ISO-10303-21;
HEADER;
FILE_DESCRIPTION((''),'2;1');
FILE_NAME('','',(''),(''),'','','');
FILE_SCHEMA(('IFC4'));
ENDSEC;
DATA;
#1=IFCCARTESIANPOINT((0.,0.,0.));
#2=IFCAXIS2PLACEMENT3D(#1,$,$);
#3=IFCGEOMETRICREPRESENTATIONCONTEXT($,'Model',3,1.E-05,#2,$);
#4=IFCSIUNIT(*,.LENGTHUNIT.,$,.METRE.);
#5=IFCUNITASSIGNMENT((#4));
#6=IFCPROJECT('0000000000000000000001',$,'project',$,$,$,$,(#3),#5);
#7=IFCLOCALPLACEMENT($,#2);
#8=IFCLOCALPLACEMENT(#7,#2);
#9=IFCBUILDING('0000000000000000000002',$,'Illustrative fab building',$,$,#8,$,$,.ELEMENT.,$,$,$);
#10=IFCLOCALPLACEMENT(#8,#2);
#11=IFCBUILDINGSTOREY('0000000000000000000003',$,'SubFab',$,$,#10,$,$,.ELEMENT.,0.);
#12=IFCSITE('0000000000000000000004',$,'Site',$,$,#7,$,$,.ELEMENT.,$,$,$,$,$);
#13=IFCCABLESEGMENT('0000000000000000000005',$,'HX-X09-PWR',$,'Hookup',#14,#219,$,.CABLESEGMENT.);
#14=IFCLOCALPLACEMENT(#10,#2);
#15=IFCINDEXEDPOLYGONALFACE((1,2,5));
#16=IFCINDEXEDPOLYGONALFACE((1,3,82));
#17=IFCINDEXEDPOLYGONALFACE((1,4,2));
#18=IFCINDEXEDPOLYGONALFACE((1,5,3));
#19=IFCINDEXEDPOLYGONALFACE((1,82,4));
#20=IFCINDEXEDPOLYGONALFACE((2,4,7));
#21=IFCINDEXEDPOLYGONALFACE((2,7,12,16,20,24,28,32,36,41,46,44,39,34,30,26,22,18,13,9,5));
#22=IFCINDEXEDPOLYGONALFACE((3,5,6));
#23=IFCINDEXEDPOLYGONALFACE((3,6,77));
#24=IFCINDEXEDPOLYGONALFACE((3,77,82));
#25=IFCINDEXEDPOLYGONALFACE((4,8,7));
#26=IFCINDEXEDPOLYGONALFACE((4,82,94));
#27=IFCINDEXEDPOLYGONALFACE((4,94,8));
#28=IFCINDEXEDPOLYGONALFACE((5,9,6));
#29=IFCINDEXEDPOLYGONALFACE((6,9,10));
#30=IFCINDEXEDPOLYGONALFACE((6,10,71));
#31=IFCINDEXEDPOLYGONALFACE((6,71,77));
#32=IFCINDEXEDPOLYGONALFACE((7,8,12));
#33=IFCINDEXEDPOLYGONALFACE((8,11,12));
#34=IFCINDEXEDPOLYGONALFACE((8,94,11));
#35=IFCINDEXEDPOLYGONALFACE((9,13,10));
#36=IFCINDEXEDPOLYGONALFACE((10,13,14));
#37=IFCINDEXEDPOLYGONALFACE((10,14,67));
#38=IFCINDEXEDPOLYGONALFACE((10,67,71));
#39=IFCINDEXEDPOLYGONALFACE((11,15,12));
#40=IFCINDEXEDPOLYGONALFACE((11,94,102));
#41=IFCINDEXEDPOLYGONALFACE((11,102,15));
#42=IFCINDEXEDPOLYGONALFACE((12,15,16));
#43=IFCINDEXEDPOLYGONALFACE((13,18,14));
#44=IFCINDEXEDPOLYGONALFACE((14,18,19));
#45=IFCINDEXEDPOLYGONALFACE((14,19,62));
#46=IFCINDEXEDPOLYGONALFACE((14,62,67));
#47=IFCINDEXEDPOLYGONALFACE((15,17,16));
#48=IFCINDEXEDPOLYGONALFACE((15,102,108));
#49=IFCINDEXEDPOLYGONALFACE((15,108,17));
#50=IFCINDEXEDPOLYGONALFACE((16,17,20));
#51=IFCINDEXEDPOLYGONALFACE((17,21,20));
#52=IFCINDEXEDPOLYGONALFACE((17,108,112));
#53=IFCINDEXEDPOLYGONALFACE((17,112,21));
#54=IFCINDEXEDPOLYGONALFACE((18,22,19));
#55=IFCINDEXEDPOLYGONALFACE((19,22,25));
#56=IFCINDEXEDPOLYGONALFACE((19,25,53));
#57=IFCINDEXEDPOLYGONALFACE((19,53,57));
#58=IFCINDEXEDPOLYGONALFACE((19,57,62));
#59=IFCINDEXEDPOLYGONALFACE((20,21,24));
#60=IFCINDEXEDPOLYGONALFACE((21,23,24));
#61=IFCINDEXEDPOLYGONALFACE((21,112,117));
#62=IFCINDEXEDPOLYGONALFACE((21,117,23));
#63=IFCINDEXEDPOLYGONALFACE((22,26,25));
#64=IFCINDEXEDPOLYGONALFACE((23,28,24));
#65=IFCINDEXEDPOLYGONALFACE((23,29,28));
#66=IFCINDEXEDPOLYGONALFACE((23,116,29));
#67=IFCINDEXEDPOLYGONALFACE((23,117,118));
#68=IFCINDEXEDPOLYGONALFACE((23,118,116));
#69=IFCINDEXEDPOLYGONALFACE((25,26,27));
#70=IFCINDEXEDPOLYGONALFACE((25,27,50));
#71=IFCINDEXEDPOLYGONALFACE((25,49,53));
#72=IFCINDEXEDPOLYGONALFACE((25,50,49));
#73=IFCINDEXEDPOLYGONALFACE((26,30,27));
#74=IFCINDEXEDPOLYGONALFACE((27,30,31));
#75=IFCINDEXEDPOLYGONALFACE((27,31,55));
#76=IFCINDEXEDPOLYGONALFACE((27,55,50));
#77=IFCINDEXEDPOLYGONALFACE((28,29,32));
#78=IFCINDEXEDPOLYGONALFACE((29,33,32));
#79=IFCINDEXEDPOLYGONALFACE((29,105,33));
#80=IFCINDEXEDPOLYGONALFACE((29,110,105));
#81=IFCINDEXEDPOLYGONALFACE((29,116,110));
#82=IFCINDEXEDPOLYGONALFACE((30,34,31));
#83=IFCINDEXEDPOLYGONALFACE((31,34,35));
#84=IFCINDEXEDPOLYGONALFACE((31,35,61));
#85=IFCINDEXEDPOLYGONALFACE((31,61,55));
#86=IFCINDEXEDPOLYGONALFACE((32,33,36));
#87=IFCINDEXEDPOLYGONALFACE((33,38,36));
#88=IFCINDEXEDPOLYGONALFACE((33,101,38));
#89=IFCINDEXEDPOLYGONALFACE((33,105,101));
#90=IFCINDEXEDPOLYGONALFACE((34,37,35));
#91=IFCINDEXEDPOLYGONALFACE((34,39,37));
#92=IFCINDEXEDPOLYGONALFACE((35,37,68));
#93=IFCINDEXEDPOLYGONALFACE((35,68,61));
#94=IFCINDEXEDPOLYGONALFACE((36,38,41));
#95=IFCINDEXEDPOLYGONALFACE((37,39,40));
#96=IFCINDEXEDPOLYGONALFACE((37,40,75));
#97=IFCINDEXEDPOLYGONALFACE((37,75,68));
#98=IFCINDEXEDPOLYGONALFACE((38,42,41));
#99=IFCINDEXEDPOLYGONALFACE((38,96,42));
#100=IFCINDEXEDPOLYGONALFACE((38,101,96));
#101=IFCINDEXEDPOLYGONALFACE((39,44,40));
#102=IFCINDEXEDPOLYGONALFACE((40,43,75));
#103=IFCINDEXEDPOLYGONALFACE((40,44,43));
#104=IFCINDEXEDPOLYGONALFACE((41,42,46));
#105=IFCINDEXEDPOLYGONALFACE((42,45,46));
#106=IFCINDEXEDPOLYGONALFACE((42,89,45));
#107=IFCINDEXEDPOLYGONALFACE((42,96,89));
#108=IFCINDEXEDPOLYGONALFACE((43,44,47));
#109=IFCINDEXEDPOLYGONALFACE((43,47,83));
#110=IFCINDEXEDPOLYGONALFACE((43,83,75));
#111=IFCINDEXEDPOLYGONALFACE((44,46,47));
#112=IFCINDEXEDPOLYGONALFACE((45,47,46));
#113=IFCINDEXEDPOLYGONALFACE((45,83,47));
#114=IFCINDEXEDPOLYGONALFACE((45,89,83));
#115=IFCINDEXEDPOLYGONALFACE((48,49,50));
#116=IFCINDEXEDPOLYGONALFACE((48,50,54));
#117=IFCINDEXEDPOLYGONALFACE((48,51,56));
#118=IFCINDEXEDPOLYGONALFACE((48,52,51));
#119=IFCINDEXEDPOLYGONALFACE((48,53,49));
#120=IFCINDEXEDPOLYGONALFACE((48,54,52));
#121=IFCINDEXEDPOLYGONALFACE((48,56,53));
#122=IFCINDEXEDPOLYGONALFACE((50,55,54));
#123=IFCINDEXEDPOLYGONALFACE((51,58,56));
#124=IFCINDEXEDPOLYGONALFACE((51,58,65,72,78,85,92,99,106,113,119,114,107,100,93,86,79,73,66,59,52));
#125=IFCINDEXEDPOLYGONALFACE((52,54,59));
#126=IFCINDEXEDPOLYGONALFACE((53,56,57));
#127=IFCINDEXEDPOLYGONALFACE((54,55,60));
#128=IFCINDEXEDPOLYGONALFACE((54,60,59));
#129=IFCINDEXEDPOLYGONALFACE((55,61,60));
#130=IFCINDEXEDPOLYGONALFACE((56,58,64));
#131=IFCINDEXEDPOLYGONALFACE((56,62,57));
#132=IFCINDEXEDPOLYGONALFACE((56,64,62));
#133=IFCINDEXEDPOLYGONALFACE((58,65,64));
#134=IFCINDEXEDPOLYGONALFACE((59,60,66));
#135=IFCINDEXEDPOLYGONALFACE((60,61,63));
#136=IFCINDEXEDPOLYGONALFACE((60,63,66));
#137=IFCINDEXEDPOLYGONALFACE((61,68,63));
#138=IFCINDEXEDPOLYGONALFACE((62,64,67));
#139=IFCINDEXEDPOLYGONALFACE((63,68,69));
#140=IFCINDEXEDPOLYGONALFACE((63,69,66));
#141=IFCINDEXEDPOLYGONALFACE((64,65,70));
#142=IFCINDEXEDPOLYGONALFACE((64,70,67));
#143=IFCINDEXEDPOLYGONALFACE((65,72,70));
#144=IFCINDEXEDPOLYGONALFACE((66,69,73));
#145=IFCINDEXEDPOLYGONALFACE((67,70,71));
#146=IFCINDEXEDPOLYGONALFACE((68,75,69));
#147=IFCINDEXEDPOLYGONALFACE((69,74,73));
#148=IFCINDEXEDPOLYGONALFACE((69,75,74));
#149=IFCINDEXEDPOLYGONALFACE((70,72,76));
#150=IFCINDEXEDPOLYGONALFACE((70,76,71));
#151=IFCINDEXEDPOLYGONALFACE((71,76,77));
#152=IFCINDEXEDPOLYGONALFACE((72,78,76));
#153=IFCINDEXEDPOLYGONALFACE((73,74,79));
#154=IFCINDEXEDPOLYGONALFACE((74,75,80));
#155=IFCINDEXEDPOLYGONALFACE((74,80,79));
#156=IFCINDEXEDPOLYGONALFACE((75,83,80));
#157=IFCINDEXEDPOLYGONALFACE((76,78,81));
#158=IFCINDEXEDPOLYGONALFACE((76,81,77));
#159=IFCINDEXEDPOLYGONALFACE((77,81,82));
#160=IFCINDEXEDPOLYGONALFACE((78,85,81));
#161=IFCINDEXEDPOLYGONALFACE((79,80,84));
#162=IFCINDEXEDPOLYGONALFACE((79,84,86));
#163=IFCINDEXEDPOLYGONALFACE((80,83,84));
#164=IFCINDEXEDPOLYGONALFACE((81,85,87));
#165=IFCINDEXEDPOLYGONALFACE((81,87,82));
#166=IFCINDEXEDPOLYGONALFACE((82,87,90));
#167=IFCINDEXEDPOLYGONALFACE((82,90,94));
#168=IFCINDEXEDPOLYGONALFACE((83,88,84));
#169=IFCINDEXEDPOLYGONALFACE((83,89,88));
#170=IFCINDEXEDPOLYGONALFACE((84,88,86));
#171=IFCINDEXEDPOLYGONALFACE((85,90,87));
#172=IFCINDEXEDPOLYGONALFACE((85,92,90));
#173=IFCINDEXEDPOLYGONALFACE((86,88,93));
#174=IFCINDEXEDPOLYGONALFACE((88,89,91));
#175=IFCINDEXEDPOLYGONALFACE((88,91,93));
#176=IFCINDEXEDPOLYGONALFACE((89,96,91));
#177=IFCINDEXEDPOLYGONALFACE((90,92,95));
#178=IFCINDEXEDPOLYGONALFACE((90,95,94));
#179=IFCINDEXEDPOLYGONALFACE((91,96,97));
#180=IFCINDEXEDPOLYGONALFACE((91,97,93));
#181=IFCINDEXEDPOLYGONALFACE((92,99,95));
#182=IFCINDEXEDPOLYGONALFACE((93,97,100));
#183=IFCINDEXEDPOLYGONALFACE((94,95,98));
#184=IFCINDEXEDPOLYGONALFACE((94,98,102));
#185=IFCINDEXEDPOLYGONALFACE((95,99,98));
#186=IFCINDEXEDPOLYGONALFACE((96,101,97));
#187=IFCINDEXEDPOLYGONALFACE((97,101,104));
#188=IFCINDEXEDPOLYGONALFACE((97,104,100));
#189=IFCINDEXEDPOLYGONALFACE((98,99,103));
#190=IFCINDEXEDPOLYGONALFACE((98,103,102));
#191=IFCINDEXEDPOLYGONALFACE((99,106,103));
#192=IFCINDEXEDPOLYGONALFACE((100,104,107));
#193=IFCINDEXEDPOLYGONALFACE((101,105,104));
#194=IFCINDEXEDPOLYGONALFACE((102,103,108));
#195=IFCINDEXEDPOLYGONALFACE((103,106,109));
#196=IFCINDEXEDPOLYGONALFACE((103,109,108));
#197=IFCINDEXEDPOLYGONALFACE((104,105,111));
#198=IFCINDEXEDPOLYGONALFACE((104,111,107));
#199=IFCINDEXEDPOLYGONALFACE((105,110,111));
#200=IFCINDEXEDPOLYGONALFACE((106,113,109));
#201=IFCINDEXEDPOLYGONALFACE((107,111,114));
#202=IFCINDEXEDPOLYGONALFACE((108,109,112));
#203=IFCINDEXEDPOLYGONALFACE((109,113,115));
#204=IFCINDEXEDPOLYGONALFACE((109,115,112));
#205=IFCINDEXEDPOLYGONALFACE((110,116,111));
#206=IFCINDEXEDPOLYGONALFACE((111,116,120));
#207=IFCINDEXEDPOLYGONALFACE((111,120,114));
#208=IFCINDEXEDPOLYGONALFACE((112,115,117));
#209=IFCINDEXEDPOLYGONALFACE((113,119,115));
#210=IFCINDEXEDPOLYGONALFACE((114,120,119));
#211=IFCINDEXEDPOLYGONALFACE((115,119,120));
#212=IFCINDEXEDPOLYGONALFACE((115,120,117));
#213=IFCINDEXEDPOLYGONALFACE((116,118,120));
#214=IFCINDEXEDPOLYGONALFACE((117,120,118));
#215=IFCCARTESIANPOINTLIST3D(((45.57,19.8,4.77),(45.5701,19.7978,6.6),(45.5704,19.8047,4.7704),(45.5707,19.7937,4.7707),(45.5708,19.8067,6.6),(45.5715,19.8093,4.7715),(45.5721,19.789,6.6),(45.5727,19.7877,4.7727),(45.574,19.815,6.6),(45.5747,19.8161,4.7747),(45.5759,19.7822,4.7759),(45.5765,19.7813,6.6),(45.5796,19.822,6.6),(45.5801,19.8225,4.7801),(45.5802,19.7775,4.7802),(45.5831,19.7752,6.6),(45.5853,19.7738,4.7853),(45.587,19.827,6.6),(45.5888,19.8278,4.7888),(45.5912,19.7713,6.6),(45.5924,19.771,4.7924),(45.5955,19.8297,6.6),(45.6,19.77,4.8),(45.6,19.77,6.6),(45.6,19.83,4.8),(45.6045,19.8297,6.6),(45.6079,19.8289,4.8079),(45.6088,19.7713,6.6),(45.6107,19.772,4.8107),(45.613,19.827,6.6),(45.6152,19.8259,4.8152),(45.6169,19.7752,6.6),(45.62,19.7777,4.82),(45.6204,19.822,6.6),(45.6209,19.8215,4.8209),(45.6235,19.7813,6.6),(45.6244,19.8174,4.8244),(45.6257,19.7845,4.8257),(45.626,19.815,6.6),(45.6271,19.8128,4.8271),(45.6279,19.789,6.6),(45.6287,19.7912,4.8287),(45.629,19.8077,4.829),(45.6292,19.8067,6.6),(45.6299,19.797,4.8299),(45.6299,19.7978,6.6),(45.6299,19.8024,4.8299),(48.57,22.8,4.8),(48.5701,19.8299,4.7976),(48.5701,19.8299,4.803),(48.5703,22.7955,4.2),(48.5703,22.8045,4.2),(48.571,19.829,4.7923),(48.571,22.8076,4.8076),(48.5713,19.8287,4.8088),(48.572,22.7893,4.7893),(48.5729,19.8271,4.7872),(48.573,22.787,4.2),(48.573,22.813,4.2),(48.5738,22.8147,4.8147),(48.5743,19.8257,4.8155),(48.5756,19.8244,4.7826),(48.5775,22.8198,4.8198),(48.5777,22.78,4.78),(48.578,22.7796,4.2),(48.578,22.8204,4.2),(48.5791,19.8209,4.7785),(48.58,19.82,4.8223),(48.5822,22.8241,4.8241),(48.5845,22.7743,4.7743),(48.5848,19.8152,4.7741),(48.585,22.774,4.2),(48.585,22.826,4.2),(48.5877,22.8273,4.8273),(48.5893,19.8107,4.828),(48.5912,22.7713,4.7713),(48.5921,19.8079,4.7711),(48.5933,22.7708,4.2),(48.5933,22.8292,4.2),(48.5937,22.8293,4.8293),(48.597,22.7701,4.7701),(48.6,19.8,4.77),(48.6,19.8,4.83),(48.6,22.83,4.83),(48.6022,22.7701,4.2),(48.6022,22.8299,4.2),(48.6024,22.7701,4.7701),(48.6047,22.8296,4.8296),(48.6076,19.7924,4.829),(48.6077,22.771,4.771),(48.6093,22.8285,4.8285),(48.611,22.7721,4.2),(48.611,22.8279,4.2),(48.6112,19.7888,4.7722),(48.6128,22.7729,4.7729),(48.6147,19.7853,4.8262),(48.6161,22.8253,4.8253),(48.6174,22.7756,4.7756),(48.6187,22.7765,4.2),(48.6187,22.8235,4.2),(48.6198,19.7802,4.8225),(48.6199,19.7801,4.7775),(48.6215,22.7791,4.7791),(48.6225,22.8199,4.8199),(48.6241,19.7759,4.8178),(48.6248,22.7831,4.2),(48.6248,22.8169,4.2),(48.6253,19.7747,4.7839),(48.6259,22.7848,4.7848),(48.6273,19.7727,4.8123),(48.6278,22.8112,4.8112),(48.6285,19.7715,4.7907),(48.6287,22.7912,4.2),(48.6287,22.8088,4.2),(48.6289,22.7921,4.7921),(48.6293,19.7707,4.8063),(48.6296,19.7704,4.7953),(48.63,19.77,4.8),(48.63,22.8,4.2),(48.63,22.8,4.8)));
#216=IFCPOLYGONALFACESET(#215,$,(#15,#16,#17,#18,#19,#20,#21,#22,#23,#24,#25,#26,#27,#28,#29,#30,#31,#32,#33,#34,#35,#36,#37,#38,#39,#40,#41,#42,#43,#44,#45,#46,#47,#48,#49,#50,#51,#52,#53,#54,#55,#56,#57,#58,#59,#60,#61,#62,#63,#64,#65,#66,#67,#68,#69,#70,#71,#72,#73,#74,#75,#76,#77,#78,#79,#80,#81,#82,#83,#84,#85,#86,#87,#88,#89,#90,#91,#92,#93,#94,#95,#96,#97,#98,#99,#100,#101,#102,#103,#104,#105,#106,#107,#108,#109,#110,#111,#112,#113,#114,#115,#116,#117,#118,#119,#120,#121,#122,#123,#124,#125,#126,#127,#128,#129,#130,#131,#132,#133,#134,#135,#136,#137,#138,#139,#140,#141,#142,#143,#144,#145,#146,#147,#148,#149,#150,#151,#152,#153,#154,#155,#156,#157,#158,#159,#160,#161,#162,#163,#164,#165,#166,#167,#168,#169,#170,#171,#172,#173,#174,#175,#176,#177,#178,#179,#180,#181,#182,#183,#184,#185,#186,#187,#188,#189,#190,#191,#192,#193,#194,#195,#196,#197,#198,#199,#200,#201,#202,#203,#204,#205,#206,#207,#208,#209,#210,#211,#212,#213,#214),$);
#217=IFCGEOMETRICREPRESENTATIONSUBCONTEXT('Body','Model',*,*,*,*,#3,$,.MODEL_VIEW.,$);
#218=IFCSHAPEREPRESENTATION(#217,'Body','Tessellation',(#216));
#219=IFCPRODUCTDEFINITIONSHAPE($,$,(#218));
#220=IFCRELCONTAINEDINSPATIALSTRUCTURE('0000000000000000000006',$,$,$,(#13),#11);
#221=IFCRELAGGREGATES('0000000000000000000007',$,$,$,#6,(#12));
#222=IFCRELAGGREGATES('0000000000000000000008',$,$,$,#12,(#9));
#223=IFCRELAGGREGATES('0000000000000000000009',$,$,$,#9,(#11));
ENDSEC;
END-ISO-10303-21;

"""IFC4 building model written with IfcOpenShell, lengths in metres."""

from ifc_helpers import new_model, entity, si_unit, origin, place, context, subcontext, project, spatial, element, save


model = new_model("IFC4")

# Units and contexts
model_context = context("Model", 3, precision=1e-05, world=origin())
body_context = subcontext(model_context, "Body", "Model", "MODEL_VIEW")
ifc_project = project(units=[si_unit("LENGTHUNIT", "METRE")], contexts=[model_context])

# Site, building, storey
site_placement = place(None, origin())
site = spatial("IfcSite", under=ifc_project, at=site_placement, Name="Site", CompositionType="ELEMENT")
building_placement = place(site_placement, origin())
building = spatial("IfcBuilding", under=site, at=building_placement, Name="Illustrative fab building", CompositionType="ELEMENT")
storey_placement = place(building_placement, origin())
storey = spatial("IfcBuildingStorey", under=building, at=storey_placement, Name="SubFab", CompositionType="ELEMENT", Elevation=0.0)

# Cable segment
cable_segment_1_placement = place(storey_placement, origin())
element("IfcCableSegment", 1, at=cable_segment_1_placement, inside=storey, Name="HX-X09-PWR", ObjectType="Hookup", PredefinedType="CABLESEGMENT", context=body_context, shape_type="AdvancedSweptSolid", body=[
    entity("IfcSweptDiskSolid", entity("IfcPolyline", [entity("IfcCartesianPoint", [48.6, 22.8, 4.2]), entity("IfcCartesianPoint", [48.6, 22.8, 4.8]), entity("IfcCartesianPoint", [48.6, 19.8, 4.8]), entity("IfcCartesianPoint", [45.6, 19.8, 4.8]), entity("IfcCartesianPoint", [45.6, 19.8, 6.6])]), 0.03),
])

save(model, "model.ifc")
